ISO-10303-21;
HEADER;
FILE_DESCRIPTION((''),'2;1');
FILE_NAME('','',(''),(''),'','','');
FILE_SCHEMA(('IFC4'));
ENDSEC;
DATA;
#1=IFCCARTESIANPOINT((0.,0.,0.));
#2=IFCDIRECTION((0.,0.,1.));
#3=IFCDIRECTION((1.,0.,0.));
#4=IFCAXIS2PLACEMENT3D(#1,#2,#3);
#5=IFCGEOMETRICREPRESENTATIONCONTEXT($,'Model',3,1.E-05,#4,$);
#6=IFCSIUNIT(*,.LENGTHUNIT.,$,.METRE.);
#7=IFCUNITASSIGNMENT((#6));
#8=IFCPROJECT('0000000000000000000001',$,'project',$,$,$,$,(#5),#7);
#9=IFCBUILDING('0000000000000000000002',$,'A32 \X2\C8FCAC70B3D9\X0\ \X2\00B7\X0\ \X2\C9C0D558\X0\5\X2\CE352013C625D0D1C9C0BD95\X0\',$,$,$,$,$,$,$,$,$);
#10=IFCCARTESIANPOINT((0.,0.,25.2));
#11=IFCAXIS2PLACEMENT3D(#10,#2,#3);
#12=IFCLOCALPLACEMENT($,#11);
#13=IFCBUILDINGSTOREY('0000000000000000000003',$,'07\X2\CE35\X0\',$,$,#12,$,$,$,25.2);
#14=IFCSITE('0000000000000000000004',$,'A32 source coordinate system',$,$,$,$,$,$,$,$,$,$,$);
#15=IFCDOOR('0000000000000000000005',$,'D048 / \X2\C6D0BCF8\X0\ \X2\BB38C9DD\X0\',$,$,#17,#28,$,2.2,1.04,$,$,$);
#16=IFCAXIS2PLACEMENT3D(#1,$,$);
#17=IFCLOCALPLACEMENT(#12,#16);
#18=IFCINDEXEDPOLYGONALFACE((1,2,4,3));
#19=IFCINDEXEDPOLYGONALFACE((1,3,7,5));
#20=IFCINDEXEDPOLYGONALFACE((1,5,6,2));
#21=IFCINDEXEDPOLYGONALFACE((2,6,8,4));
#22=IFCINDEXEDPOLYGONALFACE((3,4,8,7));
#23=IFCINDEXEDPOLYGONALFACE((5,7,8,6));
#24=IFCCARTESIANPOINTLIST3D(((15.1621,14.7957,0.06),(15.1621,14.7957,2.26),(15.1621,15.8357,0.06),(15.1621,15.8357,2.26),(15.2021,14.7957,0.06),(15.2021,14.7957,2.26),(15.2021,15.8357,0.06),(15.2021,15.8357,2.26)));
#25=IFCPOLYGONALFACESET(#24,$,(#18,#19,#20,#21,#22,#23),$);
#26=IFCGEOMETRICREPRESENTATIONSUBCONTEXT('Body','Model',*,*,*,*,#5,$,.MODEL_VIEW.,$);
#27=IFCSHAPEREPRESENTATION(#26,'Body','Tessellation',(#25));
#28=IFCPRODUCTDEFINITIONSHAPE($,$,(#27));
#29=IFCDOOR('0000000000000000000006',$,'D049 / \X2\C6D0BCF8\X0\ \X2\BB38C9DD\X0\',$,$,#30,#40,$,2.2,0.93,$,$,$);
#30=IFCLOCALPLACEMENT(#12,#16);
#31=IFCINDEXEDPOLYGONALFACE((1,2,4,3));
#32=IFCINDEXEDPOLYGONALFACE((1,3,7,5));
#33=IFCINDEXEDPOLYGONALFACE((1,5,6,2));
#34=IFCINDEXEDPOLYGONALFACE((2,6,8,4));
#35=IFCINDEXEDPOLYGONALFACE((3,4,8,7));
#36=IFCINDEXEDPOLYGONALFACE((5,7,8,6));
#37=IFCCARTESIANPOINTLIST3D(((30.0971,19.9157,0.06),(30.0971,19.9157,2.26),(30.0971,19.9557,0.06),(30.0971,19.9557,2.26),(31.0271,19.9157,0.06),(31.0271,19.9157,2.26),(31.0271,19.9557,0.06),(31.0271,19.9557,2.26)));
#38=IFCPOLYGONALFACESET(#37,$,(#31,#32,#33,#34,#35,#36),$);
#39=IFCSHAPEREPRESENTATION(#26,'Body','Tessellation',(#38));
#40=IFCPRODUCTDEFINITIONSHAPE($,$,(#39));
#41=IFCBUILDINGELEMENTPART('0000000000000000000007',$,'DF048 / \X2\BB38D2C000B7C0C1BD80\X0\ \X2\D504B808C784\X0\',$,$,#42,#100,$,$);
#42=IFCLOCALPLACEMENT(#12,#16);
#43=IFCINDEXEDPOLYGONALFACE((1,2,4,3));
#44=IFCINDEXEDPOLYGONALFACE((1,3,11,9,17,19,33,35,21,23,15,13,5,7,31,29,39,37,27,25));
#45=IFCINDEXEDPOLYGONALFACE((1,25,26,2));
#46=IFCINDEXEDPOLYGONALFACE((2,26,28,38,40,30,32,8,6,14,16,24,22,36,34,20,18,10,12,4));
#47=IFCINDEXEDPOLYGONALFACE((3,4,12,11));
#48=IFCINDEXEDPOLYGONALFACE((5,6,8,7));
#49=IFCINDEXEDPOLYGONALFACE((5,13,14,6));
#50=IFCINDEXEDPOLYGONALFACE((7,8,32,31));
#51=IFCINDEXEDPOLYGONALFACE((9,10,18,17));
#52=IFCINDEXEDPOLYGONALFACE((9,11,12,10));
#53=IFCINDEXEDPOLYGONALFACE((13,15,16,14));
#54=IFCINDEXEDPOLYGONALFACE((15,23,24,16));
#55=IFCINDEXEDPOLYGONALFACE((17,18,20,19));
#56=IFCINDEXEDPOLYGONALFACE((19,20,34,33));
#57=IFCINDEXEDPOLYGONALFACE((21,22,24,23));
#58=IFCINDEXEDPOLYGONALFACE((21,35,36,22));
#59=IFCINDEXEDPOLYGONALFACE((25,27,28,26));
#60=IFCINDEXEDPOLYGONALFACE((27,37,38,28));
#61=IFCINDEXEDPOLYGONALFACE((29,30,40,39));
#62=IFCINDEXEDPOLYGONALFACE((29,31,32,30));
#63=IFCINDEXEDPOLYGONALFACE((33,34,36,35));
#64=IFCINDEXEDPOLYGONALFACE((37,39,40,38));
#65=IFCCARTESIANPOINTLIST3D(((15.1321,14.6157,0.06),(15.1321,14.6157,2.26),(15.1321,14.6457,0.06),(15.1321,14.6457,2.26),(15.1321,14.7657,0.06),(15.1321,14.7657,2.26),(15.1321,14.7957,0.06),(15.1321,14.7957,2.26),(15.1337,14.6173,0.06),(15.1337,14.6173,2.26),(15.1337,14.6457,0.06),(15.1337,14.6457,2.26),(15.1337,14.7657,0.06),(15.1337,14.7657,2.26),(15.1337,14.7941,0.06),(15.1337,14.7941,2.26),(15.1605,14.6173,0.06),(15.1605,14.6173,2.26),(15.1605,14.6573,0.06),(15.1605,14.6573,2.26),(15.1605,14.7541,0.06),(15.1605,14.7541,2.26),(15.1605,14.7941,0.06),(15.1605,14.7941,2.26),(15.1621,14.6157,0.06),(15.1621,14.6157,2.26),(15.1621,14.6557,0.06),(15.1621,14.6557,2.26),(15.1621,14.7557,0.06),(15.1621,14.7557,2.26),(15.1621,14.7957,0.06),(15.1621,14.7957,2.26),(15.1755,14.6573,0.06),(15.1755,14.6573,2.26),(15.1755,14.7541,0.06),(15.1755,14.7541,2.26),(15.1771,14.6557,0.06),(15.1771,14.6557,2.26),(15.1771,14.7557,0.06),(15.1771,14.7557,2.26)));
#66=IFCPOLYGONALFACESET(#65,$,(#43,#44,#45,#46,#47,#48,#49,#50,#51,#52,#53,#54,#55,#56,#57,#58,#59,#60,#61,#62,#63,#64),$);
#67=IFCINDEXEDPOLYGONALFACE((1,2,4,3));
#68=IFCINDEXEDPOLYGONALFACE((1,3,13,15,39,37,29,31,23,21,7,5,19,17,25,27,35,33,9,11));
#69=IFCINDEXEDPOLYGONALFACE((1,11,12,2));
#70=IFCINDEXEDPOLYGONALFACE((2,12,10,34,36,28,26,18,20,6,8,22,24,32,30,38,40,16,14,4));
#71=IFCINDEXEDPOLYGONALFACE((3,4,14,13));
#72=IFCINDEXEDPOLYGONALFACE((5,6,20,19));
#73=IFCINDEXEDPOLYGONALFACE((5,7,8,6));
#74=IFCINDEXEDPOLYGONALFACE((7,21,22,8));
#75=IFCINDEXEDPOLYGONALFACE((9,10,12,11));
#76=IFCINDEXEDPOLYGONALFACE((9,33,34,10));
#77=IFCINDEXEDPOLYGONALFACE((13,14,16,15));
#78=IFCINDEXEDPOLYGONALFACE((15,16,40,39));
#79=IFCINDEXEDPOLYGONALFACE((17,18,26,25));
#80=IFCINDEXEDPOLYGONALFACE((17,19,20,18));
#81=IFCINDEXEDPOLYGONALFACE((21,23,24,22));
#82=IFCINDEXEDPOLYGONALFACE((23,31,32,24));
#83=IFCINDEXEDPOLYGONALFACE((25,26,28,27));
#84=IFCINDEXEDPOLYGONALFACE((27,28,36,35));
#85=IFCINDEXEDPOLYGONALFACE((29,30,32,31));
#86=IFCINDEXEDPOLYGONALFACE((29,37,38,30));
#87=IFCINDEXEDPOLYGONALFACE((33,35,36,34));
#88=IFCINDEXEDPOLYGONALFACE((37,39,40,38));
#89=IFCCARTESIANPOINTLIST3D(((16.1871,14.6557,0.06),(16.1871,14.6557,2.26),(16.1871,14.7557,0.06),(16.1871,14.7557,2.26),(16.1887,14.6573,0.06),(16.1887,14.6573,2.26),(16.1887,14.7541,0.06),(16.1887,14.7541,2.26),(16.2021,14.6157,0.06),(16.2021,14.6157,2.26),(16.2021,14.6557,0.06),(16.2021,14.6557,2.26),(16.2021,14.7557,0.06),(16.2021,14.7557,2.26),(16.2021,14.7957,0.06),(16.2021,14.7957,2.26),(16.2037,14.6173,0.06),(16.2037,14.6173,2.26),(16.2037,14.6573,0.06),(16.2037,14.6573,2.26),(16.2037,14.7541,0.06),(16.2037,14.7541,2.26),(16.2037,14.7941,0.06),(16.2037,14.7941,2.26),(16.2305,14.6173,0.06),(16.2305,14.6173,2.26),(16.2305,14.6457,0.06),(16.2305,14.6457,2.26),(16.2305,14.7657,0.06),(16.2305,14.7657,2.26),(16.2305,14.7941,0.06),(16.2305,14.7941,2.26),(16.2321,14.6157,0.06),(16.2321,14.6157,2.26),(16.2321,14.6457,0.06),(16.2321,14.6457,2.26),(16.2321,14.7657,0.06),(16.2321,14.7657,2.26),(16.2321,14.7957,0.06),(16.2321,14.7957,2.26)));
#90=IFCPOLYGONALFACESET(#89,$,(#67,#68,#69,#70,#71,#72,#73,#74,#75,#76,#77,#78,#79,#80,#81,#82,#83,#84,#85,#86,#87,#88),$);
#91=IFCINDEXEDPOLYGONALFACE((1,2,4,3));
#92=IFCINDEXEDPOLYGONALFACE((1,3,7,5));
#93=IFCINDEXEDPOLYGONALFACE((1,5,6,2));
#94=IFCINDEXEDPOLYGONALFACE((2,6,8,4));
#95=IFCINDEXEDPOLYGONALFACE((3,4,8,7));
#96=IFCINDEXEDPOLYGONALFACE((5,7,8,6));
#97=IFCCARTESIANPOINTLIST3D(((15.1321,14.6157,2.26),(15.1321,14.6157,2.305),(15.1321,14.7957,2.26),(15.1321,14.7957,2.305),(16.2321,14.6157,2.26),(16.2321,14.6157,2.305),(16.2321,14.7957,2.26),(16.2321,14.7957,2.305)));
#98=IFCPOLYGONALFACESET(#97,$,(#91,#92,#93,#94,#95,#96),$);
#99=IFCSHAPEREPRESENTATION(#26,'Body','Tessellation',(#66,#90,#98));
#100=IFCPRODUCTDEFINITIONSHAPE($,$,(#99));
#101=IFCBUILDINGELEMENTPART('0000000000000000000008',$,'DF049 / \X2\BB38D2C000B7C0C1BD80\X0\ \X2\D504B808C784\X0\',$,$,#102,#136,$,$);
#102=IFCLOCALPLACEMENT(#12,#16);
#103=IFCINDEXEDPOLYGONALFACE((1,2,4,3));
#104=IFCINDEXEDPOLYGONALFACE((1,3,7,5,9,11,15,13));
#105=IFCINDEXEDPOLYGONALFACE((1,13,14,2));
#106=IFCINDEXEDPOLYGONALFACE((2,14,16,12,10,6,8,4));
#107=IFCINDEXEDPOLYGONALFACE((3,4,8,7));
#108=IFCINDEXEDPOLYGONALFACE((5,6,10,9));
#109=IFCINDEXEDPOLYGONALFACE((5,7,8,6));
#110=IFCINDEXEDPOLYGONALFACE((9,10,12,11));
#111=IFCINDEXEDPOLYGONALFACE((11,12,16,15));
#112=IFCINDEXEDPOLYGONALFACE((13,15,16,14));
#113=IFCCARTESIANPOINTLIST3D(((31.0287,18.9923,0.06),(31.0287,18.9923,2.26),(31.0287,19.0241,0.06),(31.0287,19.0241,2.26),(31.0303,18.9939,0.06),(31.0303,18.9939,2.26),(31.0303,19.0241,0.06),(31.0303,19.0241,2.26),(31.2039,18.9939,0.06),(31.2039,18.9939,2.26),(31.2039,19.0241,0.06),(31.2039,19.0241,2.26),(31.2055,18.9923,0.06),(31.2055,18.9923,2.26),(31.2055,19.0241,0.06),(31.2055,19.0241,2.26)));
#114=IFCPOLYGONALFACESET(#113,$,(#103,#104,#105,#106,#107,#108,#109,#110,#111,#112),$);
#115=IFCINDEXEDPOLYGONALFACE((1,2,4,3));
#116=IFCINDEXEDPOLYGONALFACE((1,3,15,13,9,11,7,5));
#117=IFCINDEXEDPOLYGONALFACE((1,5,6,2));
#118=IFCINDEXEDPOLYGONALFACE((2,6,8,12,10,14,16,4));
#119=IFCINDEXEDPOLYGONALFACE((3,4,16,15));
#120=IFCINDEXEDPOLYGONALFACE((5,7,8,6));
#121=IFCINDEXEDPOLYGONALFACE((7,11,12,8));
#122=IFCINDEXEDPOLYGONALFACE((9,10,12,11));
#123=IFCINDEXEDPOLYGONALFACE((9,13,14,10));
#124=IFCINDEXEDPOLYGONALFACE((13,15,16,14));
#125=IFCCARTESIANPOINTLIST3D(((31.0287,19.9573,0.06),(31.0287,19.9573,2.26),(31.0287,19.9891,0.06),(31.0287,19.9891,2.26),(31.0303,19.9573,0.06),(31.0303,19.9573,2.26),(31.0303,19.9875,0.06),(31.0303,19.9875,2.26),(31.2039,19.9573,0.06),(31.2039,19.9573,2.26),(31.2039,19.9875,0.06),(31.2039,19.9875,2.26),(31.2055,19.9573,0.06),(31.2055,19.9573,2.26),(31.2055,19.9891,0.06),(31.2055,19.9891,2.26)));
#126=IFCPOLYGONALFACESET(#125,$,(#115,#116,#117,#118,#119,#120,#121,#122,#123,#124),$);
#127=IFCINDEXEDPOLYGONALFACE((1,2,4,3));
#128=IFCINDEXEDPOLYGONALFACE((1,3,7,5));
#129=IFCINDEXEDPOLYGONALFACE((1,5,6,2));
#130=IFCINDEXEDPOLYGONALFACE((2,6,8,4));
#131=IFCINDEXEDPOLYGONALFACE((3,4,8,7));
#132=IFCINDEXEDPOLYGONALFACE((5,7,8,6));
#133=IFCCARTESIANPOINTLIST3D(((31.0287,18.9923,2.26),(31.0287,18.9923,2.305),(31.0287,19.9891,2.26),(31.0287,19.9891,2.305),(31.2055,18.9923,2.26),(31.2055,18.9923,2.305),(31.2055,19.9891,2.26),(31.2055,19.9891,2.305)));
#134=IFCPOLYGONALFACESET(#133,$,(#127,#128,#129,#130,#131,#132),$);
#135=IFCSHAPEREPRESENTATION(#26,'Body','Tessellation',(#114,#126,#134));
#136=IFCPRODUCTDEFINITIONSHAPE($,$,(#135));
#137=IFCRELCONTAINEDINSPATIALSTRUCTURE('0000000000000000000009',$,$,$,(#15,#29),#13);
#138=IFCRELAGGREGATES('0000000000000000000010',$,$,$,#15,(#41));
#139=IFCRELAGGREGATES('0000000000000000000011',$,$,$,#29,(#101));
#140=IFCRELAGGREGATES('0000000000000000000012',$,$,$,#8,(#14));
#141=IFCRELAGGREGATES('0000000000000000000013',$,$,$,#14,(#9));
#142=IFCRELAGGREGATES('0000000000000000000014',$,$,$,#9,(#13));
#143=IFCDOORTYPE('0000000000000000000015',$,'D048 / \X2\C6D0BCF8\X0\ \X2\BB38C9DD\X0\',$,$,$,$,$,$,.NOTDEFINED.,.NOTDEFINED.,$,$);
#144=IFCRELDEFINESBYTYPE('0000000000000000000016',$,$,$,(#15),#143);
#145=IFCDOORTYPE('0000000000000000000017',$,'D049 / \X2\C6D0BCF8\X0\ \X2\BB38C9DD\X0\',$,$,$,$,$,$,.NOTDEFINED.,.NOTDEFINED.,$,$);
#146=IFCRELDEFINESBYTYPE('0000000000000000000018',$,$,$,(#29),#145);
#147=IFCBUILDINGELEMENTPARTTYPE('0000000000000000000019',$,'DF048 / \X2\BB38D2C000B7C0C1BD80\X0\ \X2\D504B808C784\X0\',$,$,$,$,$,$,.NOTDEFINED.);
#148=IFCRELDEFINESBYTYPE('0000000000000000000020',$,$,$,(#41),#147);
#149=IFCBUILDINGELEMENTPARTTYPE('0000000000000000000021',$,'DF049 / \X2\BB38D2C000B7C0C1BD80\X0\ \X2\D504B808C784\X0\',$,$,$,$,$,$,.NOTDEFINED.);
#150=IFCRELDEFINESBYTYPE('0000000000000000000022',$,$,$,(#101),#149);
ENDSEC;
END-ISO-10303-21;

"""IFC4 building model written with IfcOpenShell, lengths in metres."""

from ifc_helpers import new_model, si_unit, frame, origin, origin_with_axes, place, context, subcontext, project, spatial, polyline, outline, extrude, source, transform, mapped, type_object, type_shapes, element, aggregate, save


model = new_model("IFC4")

# Units and contexts
model_context = context("Model", 3, precision=1e-05, world=origin_with_axes())
body_context = subcontext(model_context, "Body", "Model", "MODEL_VIEW")
ifc_project = project(units=[si_unit("LENGTHUNIT", "METRE")], contexts=[model_context])

# Site, building, storey
storey_placement = place(None, frame((0.0, 0.0, 25.2), z_axis=(0.0, 0.0, 1.0), x_axis=(1.0, 0.0, 0.0)))
site = spatial("IfcSite", under=ifc_project, Name="A32 source coordinate system")
building = spatial("IfcBuilding", under=site, Name="A32 주거동 · 지하5층–옥탑지붕")
storey = spatial("IfcBuildingStorey", under=building, at=storey_placement, Name="07층", Elevation=25.2)

# Doors
door_type_1 = type_object("IfcDoorType", Name="D048 / 원본 문짝", OperationType="NOTDEFINED", PredefinedType="NOTDEFINED")
shared_shape_1 = source(origin(), body_context, "Body", "SweptSolid", [
    extrude(outline(polyline([(15.2021, 15.8357), (15.2021, 14.7957), (15.1621, 14.7957), (15.1621, 15.8357), (15.2021, 15.8357)])), frame((0.0, 0.0, 0.06)), (0.0, 0.0, 1.0), 2.2),
])
type_shapes(door_type_1, [shared_shape_1])
door_1_placement = place(storey_placement, origin_with_axes())
door_1 = element("IfcDoor", 1, at=door_1_placement, inside=storey, type_object=door_type_1, Name="D048 / 원본 문짝", OverallHeight=2.2, OverallWidth=1.04, context=body_context, shape_type="MappedRepresentation", body=[
    mapped(shared_shape_1, transform((0.0, 0.0, 0.0), scale=1.0)),
])
door_type_2 = type_object("IfcDoorType", Name="D049 / 원본 문짝", OperationType="NOTDEFINED", PredefinedType="NOTDEFINED")
shared_shape_2 = source(origin(), body_context, "Body", "SweptSolid", [
    extrude(outline(polyline([(31.0271, 19.9557), (31.0271, 19.9157), (30.0971, 19.9157), (30.0971, 19.9557), (31.0271, 19.9557)])), frame((0.0, 0.0, 0.06)), (0.0, 0.0, 1.0), 2.2),
])
type_shapes(door_type_2, [shared_shape_2])
door_2_placement = place(storey_placement, origin_with_axes())
door_2 = element("IfcDoor", 2, at=door_2_placement, inside=storey, type_object=door_type_2, Name="D049 / 원본 문짝", OverallHeight=2.2, OverallWidth=0.93, context=body_context, shape_type="MappedRepresentation", body=[
    mapped(shared_shape_2, transform((0.0, 0.0, 0.0), scale=1.0)),
])

# Building element parts
building_element_part_type_1 = type_object("IfcBuildingElementPartType", Name="DF048 / 문틀·상부 프레임", PredefinedType="NOTDEFINED")
shared_shape_3 = source(origin(), body_context, "Body", "SweptSolid", [
    extrude(outline(polyline([(15.1321, 14.7657), (15.1321, 14.7957), (15.1621, 14.7957), (15.1621, 14.7557), (15.1771, 14.7557), (15.1771, 14.6557), (15.1621, 14.6557), (15.1621, 14.6157), (15.1321, 14.6157), (15.1321, 14.6457), (15.1337, 14.6457), (15.1337, 14.6173), (15.1605, 14.6173), (15.1605, 14.6573), (15.1755, 14.6573), (15.1755, 14.7541), (15.1605, 14.7541), (15.1605, 14.7941), (15.1337, 14.7941), (15.1337, 14.7657), (15.1321, 14.7657)])), frame((0.0, 0.0, 0.06)), (0.0, 0.0, 1.0), 2.2),
    extrude(outline(polyline([(16.2305, 14.7941), (16.2037, 14.7941), (16.2037, 14.7541), (16.1887, 14.7541), (16.1887, 14.6573), (16.2037, 14.6573), (16.2037, 14.6173), (16.2305, 14.6173), (16.2305, 14.6457), (16.2321, 14.6457), (16.2321, 14.6157), (16.2021, 14.6157), (16.2021, 14.6557), (16.1871, 14.6557), (16.1871, 14.7557), (16.2021, 14.7557), (16.2021, 14.7957), (16.2321, 14.7957), (16.2321, 14.7657), (16.2305, 14.7657), (16.2305, 14.7941)])), frame((0.0, 0.0, 0.06)), (0.0, 0.0, 1.0), 2.2),
    extrude(outline(polyline([(15.1321, 14.6157), (15.1321, 14.7957), (16.2321, 14.7957), (16.2321, 14.6157), (15.1321, 14.6157)])), frame((0.0, 0.0, 2.26)), (0.0, 0.0, 1.0), 0.045),
])
type_shapes(building_element_part_type_1, [shared_shape_3])
building_element_part_1_placement = place(door_1_placement, origin_with_axes())
building_element_part_1 = element("IfcBuildingElementPart", 3, at=building_element_part_1_placement, type_object=building_element_part_type_1, Name="DF048 / 문틀·상부 프레임", context=body_context, shape_type="MappedRepresentation", body=[
    mapped(shared_shape_3, transform((0.0, 0.0, 0.0), scale=1.0)),
])
aggregate(door_1, [building_element_part_1])
building_element_part_type_2 = type_object("IfcBuildingElementPartType", Name="DF049 / 문틀·상부 프레임", PredefinedType="NOTDEFINED")
shared_shape_4 = source(origin(), body_context, "Body", "SweptSolid", [
    extrude(outline(polyline([(31.0303, 19.0241), (31.0303, 18.9939), (31.2039, 18.9939), (31.2039, 19.0241), (31.2055, 19.0241), (31.2055, 18.9923), (31.0287, 18.9923), (31.0287, 19.0241), (31.0303, 19.0241)])), frame((0.0, 0.0, 0.06)), (0.0, 0.0, 1.0), 2.2),
    extrude(outline(polyline([(31.0287, 19.9891), (31.2055, 19.9891), (31.2055, 19.9573), (31.2039, 19.9573), (31.2039, 19.9875), (31.0303, 19.9875), (31.0303, 19.9573), (31.0287, 19.9573), (31.0287, 19.9891)])), frame((0.0, 0.0, 0.06)), (0.0, 0.0, 1.0), 2.2),
    extrude(outline(polyline([(31.0287, 18.9923), (31.0287, 19.9891), (31.2055, 19.9891), (31.2055, 18.9923), (31.0287, 18.9923)])), frame((0.0, 0.0, 2.26)), (0.0, 0.0, 1.0), 0.045),
])
type_shapes(building_element_part_type_2, [shared_shape_4])
building_element_part_2_placement = place(door_2_placement, origin_with_axes())
building_element_part_2 = element("IfcBuildingElementPart", 4, at=building_element_part_2_placement, type_object=building_element_part_type_2, Name="DF049 / 문틀·상부 프레임", context=body_context, shape_type="MappedRepresentation", body=[
    mapped(shared_shape_4, transform((0.0, 0.0, 0.0), scale=1.0)),
])
aggregate(door_2, [building_element_part_2])

save(model, "model.ifc")
